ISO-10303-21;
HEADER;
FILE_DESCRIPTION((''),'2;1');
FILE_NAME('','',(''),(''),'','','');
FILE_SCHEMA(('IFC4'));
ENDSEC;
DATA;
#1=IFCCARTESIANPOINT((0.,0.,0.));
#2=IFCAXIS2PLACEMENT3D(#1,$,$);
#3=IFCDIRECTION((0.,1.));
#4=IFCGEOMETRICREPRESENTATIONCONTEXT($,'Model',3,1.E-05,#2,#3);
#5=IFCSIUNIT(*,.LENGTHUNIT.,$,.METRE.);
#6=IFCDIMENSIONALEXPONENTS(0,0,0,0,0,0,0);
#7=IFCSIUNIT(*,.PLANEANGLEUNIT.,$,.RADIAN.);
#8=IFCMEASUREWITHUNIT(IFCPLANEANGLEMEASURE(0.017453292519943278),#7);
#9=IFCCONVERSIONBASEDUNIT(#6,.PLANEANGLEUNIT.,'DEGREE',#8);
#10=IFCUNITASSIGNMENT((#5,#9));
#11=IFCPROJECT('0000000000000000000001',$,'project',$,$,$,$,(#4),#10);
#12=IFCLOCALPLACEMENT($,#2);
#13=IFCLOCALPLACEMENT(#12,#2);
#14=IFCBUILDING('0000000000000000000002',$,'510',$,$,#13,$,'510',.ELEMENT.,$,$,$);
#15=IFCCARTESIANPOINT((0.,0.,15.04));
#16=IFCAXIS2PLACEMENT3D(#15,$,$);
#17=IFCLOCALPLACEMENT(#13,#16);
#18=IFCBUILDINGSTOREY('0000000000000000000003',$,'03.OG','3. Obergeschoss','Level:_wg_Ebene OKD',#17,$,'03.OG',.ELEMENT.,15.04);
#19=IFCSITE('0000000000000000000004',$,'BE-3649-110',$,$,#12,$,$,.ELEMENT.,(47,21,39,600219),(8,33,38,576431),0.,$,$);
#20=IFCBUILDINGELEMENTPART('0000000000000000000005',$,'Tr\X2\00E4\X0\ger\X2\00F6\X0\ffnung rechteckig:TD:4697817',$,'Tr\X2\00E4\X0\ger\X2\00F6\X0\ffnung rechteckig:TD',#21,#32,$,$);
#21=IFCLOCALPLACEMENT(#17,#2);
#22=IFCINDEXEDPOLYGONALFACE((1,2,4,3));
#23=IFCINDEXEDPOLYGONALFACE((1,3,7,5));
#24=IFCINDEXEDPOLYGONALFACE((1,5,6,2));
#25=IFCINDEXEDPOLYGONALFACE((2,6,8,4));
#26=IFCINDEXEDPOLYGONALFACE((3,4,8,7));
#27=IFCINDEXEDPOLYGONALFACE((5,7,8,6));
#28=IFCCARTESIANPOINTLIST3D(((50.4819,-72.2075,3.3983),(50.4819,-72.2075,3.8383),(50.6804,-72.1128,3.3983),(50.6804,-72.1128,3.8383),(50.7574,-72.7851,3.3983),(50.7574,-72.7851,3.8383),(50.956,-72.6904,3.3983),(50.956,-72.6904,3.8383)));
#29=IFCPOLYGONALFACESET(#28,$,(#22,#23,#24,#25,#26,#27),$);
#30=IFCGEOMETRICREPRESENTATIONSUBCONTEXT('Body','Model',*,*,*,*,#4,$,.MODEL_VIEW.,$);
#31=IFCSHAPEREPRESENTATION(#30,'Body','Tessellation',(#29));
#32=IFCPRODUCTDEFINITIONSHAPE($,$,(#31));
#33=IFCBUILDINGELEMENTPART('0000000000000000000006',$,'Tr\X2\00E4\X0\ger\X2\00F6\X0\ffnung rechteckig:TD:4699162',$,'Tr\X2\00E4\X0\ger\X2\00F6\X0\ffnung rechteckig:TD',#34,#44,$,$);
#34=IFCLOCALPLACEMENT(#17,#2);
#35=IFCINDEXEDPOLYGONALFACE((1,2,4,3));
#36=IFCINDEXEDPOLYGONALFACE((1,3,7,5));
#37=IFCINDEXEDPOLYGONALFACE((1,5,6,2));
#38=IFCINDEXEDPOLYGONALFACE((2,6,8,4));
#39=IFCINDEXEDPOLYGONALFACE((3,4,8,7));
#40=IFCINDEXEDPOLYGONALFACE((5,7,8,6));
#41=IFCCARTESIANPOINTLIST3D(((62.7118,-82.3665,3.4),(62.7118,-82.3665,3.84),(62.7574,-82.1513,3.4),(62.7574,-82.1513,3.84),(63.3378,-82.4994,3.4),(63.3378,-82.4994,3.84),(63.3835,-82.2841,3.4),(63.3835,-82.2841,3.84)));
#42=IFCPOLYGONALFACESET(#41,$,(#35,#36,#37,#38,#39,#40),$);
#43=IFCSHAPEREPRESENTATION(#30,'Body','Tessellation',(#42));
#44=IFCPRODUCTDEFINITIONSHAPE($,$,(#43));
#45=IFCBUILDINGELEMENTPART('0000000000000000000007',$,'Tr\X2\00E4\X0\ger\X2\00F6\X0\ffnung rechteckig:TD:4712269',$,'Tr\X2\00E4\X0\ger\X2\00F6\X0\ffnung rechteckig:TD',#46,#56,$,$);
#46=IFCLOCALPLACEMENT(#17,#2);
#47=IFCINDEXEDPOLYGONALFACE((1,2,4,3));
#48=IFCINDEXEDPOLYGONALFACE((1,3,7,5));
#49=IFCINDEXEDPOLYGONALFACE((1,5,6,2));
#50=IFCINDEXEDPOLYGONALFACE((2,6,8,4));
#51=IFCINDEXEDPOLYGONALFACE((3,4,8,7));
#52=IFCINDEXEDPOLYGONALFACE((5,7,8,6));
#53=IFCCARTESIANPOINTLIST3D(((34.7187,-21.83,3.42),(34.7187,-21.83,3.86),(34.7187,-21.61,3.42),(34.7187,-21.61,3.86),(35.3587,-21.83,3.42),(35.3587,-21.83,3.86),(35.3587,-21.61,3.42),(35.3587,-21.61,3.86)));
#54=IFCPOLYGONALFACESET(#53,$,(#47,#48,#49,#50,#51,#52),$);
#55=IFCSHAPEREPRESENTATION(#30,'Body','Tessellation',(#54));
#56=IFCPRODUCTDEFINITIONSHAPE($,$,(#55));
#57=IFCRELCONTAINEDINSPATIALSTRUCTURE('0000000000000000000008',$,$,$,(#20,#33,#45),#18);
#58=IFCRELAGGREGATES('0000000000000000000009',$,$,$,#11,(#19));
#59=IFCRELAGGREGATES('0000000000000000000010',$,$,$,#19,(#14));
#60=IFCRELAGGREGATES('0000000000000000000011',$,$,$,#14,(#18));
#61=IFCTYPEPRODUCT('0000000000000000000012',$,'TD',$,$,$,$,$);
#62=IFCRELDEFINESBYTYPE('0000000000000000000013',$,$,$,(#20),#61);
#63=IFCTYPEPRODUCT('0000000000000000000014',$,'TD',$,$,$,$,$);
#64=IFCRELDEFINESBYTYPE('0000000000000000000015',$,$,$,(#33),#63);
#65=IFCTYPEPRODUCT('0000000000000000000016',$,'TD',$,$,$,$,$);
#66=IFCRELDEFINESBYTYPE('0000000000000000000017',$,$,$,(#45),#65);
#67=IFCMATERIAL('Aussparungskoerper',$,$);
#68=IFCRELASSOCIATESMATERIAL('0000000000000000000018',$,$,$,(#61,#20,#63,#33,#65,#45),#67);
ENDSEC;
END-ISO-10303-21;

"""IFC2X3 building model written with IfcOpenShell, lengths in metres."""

from ifc_helpers import new_model, entity, si_unit, converted_unit, direction, frame, frame_2d, origin, origin_2d_with_axis, place, context, subcontext, project, spatial, rectangle, extrude, source, transform, mapped, material, type_object, type_shapes, element, save


model = new_model("IFC2X3")

# Units and contexts
model_context = context("Model", 3, precision=1e-05, world=origin(), true_north=direction((0.0, 1.0)))
body_context = subcontext(model_context, "Body", "Model", "MODEL_VIEW")
ifc_project = project(units=[si_unit("LENGTHUNIT", "METRE"), converted_unit("PLANEANGLEUNIT", "DEGREE", entity("IfcPlaneAngleMeasure", 0.017453292519943278), si_unit("PLANEANGLEUNIT", "RADIAN"), dimensions=[0, 0, 0, 0, 0, 0, 0])], contexts=[model_context])

# Site, building, storey
site_placement = place(None, origin())
site = spatial("IfcSite", under=ifc_project, at=site_placement, Name="BE-3649-110", CompositionType="ELEMENT", RefLatitude=(47, 21, 39, 600219), RefLongitude=(8, 33, 38, 576431), RefElevation=0.0)
building_placement = place(site_placement, origin())
building = spatial("IfcBuilding", under=site, at=building_placement, Name="510", LongName="510", CompositionType="ELEMENT")
storey_placement = place(building_placement, frame((0.0, 0.0, 15.04)))
storey = spatial("IfcBuildingStorey", under=building, at=storey_placement, Name="03.OG", Description="3. Obergeschoss", ObjectType="Level:_wg_Ebene OKD", LongName="03.OG", CompositionType="ELEMENT", Elevation=15.04)

# Building element parts
ifc_material_1 = material(Name="Aussparungskoerper")
type_product_1 = type_object("IfcTypeProduct", Name="TD", material=ifc_material_1)
shared_shape_1 = source(origin(), body_context, "Body", "SweptSolid", [
    extrude(rectangle(XDim=0.22, YDim=0.64, at=frame_2d((0.0, 0.0), x_axis=(1.0, 0.0))), frame((50.7189, -72.449, -0.44), z_axis=(0.0, 0.0, 1.0), x_axis=(0.902586, 0.43051, 0.0)), (0.0, 0.0, 1.0), 0.44),
])
type_shapes(type_product_1, [shared_shape_1])
building_element_part_1_placement = place(storey_placement, frame((0.0, 0.0, 3.8383)))
element("IfcBuildingElementPart", 1, at=building_element_part_1_placement, inside=storey, type_object=type_product_1, material=ifc_material_1, Name="Trägeröffnung rechteckig:TD:4697817", ObjectType="Trägeröffnung rechteckig:TD", context=body_context, shape_type="MappedRepresentation", body=[
    mapped(shared_shape_1, transform((0.0, 0.0, 0.0), scale=1.0)),
])
type_product_2 = type_object("IfcTypeProduct", Name="TD", material=ifc_material_1)
shared_shape_2 = source(origin(), body_context, "Body", "SweptSolid", [
    extrude(rectangle(XDim=0.44, YDim=0.64, at=origin_2d_with_axis()), frame((0.0, 0.0, -0.22), z_axis=(0.0, 0.0, 1.0), x_axis=(0.0, 1.0, 0.0)), (0.0, 0.0, 1.0), 0.22),
])
type_shapes(type_product_2, [shared_shape_2])
building_element_part_2_placement = place(storey_placement, frame((63.0248, -82.4329, 3.62), z_axis=(-0.207566, -0.978221, 0.0), x_axis=(0.978221, -0.207566, 0.0)))
element("IfcBuildingElementPart", 2, at=building_element_part_2_placement, inside=storey, type_object=type_product_2, material=ifc_material_1, Name="Trägeröffnung rechteckig:TD:4699162", ObjectType="Trägeröffnung rechteckig:TD", context=body_context, shape_type="MappedRepresentation", body=[
    mapped(shared_shape_2, transform((0.0, 0.0, 0.0), scale=1.0)),
])
type_product_3 = type_object("IfcTypeProduct", Name="TD", material=ifc_material_1)
shared_shape_3 = source(origin(), body_context, "Body", "SweptSolid", [
    extrude(rectangle(XDim=0.22, YDim=0.64, at=frame_2d((0.0, 0.0), x_axis=(1.0, 0.0))), frame((35.0387, -21.72, -0.44), z_axis=(0.0, 0.0, 1.0), x_axis=(0.0, 1.0, 0.0)), (0.0, 0.0, 1.0), 0.44),
])
type_shapes(type_product_3, [shared_shape_3])
building_element_part_3_placement = place(storey_placement, frame((0.0, 0.0, 3.86)))
element("IfcBuildingElementPart", 3, at=building_element_part_3_placement, inside=storey, type_object=type_product_3, material=ifc_material_1, Name="Trägeröffnung rechteckig:TD:4712269", ObjectType="Trägeröffnung rechteckig:TD", context=body_context, shape_type="MappedRepresentation", body=[
    mapped(shared_shape_3, transform((0.0, 0.0, 0.0), scale=1.0)),
])

save(model, "model.ifc")
